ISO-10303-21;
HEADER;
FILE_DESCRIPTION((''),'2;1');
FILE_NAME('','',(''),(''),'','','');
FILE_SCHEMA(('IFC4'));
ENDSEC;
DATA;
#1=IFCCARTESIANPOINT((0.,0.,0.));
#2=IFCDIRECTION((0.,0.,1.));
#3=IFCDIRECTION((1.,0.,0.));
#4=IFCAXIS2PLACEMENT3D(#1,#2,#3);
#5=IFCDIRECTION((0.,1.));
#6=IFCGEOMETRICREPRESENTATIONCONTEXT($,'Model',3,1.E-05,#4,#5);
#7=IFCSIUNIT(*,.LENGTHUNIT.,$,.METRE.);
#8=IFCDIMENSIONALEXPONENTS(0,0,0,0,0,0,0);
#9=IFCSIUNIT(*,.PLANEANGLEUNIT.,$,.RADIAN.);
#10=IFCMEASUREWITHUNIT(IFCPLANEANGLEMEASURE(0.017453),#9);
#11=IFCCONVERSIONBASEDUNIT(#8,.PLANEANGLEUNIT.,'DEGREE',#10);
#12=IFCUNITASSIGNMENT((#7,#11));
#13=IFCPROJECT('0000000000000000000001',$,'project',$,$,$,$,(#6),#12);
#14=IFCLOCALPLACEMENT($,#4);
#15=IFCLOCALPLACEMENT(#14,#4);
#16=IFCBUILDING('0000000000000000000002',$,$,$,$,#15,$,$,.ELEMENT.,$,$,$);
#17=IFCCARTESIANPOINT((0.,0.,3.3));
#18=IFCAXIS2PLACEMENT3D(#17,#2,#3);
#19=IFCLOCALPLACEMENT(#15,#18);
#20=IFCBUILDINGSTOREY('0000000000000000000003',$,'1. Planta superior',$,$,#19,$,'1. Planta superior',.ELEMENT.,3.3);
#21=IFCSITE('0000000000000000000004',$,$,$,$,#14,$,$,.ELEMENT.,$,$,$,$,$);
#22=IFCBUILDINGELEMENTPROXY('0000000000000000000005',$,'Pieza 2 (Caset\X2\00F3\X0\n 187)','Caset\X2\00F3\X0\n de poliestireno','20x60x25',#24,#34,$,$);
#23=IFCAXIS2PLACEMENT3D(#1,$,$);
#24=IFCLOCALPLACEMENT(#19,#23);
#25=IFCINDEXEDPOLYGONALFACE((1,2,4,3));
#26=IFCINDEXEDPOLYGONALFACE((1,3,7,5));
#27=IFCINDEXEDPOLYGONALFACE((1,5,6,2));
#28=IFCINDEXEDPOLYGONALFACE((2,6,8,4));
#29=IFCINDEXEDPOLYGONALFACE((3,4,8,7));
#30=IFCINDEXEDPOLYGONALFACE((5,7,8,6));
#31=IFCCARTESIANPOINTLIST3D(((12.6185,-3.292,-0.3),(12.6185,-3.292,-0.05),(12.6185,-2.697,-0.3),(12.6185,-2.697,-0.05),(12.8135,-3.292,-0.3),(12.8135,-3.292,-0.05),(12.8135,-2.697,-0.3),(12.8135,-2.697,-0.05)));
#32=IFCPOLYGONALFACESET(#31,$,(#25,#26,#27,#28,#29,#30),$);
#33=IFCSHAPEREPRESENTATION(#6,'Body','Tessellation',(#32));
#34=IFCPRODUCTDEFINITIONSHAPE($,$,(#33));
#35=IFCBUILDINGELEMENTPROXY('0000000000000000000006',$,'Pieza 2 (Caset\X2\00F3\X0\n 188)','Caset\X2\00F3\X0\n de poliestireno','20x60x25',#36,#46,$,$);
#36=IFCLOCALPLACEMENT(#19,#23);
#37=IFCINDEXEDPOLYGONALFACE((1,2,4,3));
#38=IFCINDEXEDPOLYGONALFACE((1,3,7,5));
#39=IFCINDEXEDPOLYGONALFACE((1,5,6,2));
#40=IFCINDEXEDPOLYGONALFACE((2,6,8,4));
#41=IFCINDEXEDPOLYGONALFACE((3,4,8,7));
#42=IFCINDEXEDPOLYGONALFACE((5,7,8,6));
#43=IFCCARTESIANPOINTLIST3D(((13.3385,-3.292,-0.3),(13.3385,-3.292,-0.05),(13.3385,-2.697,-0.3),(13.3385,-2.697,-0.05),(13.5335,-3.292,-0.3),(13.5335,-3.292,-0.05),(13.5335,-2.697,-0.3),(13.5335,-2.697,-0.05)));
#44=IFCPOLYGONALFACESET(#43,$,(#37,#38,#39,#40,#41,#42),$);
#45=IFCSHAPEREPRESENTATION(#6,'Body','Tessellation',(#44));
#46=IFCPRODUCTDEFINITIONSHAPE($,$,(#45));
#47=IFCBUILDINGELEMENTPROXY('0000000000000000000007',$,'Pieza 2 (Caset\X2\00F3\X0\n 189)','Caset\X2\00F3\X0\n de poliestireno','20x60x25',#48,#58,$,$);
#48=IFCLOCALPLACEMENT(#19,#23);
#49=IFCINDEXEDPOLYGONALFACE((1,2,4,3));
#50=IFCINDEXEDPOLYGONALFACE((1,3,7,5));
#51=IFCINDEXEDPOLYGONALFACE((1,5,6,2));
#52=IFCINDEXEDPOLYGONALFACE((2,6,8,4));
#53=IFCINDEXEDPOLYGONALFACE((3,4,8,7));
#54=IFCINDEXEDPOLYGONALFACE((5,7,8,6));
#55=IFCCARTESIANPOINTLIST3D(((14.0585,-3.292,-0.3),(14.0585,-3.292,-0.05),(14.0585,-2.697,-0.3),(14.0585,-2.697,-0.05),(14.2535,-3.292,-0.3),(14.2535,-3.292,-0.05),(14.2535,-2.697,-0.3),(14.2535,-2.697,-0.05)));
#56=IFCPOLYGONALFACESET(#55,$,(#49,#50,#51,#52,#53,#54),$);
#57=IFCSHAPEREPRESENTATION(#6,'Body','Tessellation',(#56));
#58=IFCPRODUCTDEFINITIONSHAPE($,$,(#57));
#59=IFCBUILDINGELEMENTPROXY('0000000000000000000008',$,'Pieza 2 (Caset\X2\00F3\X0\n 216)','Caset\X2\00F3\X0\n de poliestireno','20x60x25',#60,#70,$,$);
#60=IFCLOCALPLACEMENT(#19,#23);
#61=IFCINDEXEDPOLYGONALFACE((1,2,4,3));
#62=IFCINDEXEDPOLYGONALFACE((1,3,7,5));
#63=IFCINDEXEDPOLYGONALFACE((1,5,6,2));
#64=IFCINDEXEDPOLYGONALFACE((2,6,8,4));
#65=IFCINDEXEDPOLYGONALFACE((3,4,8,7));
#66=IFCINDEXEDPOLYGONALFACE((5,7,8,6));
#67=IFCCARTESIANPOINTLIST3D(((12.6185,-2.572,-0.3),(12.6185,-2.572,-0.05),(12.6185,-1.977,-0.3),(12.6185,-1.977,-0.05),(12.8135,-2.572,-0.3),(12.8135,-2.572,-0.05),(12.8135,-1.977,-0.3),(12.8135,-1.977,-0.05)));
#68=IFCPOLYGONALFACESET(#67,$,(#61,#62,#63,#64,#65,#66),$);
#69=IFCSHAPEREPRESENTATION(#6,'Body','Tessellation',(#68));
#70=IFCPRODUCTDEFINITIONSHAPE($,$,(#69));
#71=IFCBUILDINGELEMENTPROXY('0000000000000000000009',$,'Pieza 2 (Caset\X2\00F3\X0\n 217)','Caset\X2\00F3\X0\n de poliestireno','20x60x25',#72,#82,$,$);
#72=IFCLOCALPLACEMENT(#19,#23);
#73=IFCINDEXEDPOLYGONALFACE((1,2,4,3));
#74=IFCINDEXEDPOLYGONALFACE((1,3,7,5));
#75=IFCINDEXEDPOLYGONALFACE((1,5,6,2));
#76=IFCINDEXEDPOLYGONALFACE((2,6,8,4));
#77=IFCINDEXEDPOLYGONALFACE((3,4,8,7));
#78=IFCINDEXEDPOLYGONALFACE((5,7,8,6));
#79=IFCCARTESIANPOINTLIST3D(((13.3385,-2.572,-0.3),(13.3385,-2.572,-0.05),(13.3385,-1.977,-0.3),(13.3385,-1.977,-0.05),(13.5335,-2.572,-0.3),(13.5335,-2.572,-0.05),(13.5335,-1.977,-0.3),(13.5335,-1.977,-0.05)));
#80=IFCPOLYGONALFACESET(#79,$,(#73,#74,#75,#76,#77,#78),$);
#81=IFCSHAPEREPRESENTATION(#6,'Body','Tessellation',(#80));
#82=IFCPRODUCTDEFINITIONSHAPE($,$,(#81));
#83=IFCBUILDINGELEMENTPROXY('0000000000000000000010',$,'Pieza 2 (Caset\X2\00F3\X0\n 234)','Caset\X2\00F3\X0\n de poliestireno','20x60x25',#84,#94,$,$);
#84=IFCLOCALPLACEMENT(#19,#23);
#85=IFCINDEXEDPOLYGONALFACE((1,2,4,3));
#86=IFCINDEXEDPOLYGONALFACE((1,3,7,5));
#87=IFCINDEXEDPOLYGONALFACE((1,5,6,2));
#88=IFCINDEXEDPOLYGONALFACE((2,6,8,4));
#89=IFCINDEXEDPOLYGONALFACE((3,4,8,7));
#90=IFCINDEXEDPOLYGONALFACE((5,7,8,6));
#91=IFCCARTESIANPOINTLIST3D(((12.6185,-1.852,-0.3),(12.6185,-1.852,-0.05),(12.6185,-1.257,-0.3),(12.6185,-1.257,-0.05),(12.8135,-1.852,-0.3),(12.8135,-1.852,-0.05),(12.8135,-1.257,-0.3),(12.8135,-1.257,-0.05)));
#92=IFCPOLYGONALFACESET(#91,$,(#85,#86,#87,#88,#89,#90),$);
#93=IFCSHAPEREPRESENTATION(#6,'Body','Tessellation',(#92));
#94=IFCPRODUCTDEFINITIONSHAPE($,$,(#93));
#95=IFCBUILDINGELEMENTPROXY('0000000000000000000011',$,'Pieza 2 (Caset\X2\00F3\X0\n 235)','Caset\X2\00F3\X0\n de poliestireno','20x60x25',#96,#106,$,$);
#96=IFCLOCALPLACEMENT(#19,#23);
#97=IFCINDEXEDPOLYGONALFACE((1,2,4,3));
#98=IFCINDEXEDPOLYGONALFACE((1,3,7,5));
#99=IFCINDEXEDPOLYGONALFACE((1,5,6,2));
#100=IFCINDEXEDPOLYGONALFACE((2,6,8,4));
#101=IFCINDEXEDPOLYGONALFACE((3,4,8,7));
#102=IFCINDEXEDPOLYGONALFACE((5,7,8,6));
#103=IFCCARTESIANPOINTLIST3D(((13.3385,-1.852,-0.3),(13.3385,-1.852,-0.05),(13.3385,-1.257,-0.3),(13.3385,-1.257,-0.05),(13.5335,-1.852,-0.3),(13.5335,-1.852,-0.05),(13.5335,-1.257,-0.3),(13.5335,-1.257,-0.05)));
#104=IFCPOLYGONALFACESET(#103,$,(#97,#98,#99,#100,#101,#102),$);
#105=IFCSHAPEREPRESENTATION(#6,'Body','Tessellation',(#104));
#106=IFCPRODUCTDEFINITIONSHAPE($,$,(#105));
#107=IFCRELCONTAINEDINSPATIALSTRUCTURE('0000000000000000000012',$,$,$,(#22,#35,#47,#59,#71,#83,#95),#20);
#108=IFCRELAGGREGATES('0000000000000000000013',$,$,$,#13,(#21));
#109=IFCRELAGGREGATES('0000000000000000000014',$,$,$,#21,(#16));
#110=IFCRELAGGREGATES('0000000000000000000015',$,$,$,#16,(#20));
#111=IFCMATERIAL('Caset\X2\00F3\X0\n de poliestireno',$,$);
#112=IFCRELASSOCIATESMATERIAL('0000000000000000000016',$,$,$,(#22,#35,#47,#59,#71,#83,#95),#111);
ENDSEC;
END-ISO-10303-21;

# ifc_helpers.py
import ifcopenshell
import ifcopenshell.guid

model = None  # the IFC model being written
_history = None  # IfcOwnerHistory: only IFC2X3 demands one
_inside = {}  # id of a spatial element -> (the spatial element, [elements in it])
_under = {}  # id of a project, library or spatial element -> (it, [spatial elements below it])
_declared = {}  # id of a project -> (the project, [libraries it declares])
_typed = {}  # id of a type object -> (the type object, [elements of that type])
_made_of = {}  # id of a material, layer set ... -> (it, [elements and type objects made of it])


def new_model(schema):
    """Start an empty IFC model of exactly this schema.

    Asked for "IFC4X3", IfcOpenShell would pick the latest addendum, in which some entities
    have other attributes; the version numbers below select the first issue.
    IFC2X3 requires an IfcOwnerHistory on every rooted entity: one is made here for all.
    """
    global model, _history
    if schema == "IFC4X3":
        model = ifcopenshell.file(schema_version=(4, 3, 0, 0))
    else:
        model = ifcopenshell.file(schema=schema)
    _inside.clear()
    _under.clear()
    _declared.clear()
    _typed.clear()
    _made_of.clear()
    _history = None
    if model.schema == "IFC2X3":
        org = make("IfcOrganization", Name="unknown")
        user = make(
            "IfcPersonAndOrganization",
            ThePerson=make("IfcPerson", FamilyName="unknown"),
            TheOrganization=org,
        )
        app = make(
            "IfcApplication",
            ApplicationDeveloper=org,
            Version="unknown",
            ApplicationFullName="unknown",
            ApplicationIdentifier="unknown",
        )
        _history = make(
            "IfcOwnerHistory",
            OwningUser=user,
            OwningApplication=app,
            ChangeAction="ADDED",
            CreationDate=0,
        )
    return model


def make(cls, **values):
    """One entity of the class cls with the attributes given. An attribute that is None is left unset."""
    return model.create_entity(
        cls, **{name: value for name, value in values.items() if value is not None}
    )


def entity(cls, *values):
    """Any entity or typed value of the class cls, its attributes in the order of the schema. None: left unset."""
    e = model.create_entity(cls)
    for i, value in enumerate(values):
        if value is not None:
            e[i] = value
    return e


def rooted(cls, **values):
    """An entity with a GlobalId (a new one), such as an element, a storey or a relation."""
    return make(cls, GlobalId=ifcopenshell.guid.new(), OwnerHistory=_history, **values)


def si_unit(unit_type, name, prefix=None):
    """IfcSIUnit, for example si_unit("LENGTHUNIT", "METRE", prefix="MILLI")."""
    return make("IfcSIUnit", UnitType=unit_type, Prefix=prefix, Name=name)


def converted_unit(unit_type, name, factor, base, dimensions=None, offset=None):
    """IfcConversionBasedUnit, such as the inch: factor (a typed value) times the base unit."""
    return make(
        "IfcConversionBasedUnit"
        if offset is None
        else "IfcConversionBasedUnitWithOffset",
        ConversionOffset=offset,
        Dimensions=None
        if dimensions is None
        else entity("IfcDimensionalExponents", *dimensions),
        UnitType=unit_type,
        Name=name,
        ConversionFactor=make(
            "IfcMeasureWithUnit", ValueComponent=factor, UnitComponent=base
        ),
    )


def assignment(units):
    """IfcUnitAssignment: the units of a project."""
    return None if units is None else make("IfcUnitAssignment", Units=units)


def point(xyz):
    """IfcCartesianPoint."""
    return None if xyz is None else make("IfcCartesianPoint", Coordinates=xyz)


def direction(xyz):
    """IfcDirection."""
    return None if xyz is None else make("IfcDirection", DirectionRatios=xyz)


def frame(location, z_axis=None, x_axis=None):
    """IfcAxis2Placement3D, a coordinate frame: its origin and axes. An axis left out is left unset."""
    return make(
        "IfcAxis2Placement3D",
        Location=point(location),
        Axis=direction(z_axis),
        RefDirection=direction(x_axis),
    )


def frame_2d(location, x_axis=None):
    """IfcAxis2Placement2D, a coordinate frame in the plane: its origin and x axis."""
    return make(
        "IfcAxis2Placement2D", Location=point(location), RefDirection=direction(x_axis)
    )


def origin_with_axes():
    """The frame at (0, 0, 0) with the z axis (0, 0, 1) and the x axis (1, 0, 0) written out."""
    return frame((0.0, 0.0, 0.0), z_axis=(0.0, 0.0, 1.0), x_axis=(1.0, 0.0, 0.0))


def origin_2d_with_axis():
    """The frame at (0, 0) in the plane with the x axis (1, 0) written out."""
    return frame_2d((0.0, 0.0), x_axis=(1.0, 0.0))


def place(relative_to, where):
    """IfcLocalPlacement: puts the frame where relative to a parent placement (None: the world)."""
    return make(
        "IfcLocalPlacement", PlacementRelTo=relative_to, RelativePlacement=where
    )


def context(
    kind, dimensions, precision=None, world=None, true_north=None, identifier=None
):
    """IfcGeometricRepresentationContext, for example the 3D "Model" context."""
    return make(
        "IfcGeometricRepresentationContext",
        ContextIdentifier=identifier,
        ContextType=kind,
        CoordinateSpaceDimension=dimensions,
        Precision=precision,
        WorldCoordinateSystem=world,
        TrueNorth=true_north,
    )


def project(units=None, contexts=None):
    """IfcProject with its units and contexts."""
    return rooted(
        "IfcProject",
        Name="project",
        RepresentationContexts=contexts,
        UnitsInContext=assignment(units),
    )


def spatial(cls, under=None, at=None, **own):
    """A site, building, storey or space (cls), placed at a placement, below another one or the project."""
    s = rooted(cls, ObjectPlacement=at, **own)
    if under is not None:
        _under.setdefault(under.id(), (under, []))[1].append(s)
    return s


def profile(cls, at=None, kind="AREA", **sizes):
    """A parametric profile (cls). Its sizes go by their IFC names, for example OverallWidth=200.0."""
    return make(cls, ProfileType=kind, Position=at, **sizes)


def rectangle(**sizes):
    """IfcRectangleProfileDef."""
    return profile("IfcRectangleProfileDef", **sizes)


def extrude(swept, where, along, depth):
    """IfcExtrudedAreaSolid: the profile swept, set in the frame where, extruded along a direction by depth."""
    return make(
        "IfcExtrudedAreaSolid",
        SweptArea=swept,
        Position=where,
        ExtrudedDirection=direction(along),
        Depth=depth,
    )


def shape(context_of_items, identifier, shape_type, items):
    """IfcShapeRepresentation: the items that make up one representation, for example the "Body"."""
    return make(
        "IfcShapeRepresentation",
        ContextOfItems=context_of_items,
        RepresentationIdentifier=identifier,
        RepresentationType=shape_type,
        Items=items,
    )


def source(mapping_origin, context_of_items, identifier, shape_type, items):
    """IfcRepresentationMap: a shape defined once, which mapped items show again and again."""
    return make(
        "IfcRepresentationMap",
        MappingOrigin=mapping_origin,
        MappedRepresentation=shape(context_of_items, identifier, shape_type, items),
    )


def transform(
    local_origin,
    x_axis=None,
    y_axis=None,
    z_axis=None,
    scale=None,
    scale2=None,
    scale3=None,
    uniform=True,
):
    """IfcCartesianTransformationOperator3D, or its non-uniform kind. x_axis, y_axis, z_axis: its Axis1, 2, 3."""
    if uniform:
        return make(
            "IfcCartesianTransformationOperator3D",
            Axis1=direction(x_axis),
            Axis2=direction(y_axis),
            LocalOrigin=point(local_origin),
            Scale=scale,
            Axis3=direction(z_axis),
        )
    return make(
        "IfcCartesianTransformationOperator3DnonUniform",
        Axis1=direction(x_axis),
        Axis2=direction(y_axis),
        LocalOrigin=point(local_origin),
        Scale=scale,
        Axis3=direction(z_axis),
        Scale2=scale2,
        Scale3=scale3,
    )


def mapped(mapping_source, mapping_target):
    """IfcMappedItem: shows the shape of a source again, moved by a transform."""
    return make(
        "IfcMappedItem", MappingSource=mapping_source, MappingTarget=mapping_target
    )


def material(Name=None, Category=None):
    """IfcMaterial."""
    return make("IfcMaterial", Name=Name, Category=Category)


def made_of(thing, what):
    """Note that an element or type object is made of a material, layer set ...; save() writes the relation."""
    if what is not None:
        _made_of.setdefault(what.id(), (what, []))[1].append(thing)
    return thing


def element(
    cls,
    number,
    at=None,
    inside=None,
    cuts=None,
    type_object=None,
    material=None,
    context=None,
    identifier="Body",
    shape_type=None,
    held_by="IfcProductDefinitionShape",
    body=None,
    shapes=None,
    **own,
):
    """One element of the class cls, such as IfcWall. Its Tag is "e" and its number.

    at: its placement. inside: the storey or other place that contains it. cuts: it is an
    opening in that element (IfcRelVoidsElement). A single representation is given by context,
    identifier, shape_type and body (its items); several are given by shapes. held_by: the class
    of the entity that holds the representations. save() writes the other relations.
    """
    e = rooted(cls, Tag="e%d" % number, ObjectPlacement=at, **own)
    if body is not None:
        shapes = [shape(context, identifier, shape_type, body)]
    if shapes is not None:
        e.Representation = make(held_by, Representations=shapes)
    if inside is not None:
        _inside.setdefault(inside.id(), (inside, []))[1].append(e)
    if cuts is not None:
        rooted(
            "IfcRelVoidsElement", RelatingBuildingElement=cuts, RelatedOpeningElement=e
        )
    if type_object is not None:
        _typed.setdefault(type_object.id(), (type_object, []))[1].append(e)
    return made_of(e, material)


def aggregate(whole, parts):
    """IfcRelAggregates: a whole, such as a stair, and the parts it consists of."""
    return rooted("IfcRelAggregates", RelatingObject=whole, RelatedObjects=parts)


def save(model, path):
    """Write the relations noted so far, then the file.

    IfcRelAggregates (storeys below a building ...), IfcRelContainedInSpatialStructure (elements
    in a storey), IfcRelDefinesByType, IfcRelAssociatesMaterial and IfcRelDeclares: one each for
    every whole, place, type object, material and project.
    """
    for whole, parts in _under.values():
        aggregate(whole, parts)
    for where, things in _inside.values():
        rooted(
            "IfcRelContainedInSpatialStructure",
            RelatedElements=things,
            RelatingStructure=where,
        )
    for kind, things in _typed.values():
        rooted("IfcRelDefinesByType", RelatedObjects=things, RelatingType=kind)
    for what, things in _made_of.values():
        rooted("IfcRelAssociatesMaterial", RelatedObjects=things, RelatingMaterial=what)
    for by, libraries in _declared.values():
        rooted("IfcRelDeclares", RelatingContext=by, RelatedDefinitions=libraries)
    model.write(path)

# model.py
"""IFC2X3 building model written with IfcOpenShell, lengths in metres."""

from ifc_helpers import new_model, entity, si_unit, converted_unit, direction, frame, origin_with_axes, origin_2d_with_axis, place, context, project, spatial, rectangle, extrude, source, transform, mapped, material, element, save


model = new_model("IFC2X3")

# Units and contexts
model_context = context("Model", 3, precision=1e-05, world=origin_with_axes(), true_north=direction((0.0, 1.0)))
ifc_project = project(units=[si_unit("LENGTHUNIT", "METRE"), converted_unit("PLANEANGLEUNIT", "DEGREE", entity("IfcPlaneAngleMeasure", 0.017453), si_unit("PLANEANGLEUNIT", "RADIAN"), dimensions=[0, 0, 0, 0, 0, 0, 0])], contexts=[model_context])

# Site, building, storey
site_placement = place(None, origin_with_axes())
site = spatial("IfcSite", under=ifc_project, at=site_placement, CompositionType="ELEMENT")
building_placement = place(site_placement, origin_with_axes())
building = spatial("IfcBuilding", under=site, at=building_placement, CompositionType="ELEMENT")
storey_placement = place(building_placement, frame((0.0, 0.0, 3.3), z_axis=(0.0, 0.0, 1.0), x_axis=(1.0, 0.0, 0.0)))
storey = spatial("IfcBuildingStorey", under=building, at=storey_placement, Name="1. Planta superior", LongName="1. Planta superior", CompositionType="ELEMENT", Elevation=3.3)

# Building element proxies
ifc_material = material(Name="Casetón de poliestireno")
shared_shape = source(origin_with_axes(), model_context, "Body", "SweptSolid", [
    extrude(rectangle(XDim=0.195, YDim=0.25, at=origin_2d_with_axis()), origin_with_axes(), (0.0, 0.0, 1.0), 0.595),
])
placement_1 = place(storey_placement, frame((12.716, -3.292, -0.175), z_axis=(0.0, 1.0, 0.0), x_axis=(-1.0, 0.0, 0.0)))
for number, where, z_axis, x_axis, name in (
    (1, (0.0, 0.0, 0.0), (0.0, 0.0, 1.0), (1.0, 0.0, 0.0), "Pieza 2 (Casetón 187)"),
):
    element("IfcBuildingElementProxy", number, at=place(placement_1, frame(where, z_axis=z_axis, x_axis=x_axis)), inside=storey, material=ifc_material, Name=name, Description="Casetón de poliestireno", ObjectType="20x60x25", context=model_context, shape_type="MappedRepresentation", body=[
        mapped(shared_shape, transform((0.0, 0.0, 0.0), x_axis=(1.0, 0.0, 0.0), y_axis=(0.0, 1.0, 0.0), z_axis=(0.0, 0.0, 1.0))),
    ])
placement_2 = place(storey_placement, frame((13.436, -3.292, -0.175), z_axis=(0.0, 1.0, 0.0), x_axis=(-1.0, 0.0, 0.0)))
for number, where, z_axis, x_axis, name in (
    (2, (0.0, 0.0, 0.0), (0.0, 0.0, 1.0), (1.0, 0.0, 0.0), "Pieza 2 (Casetón 188)"),
):
    element("IfcBuildingElementProxy", number, at=place(placement_2, frame(where, z_axis=z_axis, x_axis=x_axis)), inside=storey, material=ifc_material, Name=name, Description="Casetón de poliestireno", ObjectType="20x60x25", context=model_context, shape_type="MappedRepresentation", body=[
        mapped(shared_shape, transform((0.0, 0.0, 0.0), x_axis=(1.0, 0.0, 0.0), y_axis=(0.0, 1.0, 0.0), z_axis=(0.0, 0.0, 1.0))),
    ])
placement_3 = place(storey_placement, frame((14.156, -3.292, -0.175), z_axis=(0.0, 1.0, 0.0), x_axis=(-1.0, 0.0, 0.0)))
for number, where, z_axis, x_axis, name in (
    (3, (0.0, 0.0, 0.0), (0.0, 0.0, 1.0), (1.0, 0.0, 0.0), "Pieza 2 (Casetón 189)"),
):
    element("IfcBuildingElementProxy", number, at=place(placement_3, frame(where, z_axis=z_axis, x_axis=x_axis)), inside=storey, material=ifc_material, Name=name, Description="Casetón de poliestireno", ObjectType="20x60x25", context=model_context, shape_type="MappedRepresentation", body=[
        mapped(shared_shape, transform((0.0, 0.0, 0.0), x_axis=(1.0, 0.0, 0.0), y_axis=(0.0, 1.0, 0.0), z_axis=(0.0, 0.0, 1.0))),
    ])
placement_4 = place(storey_placement, frame((12.716, -2.572, -0.175), z_axis=(0.0, 1.0, 0.0), x_axis=(-1.0, 0.0, 0.0)))
for number, where, z_axis, x_axis, name in (
    (4, (0.0, 0.0, 0.0), (0.0, 0.0, 1.0), (1.0, 0.0, 0.0), "Pieza 2 (Casetón 216)"),
):
    element("IfcBuildingElementProxy", number, at=place(placement_4, frame(where, z_axis=z_axis, x_axis=x_axis)), inside=storey, material=ifc_material, Name=name, Description="Casetón de poliestireno", ObjectType="20x60x25", context=model_context, shape_type="MappedRepresentation", body=[
        mapped(shared_shape, transform((0.0, 0.0, 0.0), x_axis=(1.0, 0.0, 0.0), y_axis=(0.0, 1.0, 0.0), z_axis=(0.0, 0.0, 1.0))),
    ])
placement_5 = place(storey_placement, frame((13.436, -2.572, -0.175), z_axis=(0.0, 1.0, 0.0), x_axis=(-1.0, 0.0, 0.0)))
for number, where, z_axis, x_axis, name in (
    (5, (0.0, 0.0, 0.0), (0.0, 0.0, 1.0), (1.0, 0.0, 0.0), "Pieza 2 (Casetón 217)"),
):
    element("IfcBuildingElementProxy", number, at=place(placement_5, frame(where, z_axis=z_axis, x_axis=x_axis)), inside=storey, material=ifc_material, Name=name, Description="Casetón de poliestireno", ObjectType="20x60x25", context=model_context, shape_type="MappedRepresentation", body=[
        mapped(shared_shape, transform((0.0, 0.0, 0.0), x_axis=(1.0, 0.0, 0.0), y_axis=(0.0, 1.0, 0.0), z_axis=(0.0, 0.0, 1.0))),
    ])
placement_6 = place(storey_placement, frame((12.716, -1.852, -0.175), z_axis=(0.0, 1.0, 0.0), x_axis=(-1.0, 0.0, 0.0)))
for number, where, z_axis, x_axis, name in (
    (6, (0.0, 0.0, 0.0), (0.0, 0.0, 1.0), (1.0, 0.0, 0.0), "Pieza 2 (Casetón 234)"),
):
    element("IfcBuildingElementProxy", number, at=place(placement_6, frame(where, z_axis=z_axis, x_axis=x_axis)), inside=storey, material=ifc_material, Name=name, Description="Casetón de poliestireno", ObjectType="20x60x25", context=model_context, shape_type="MappedRepresentation", body=[
        mapped(shared_shape, transform((0.0, 0.0, 0.0), x_axis=(1.0, 0.0, 0.0), y_axis=(0.0, 1.0, 0.0), z_axis=(0.0, 0.0, 1.0))),
    ])
placement_7 = place(storey_placement, frame((13.436, -1.852, -0.175), z_axis=(0.0, 1.0, 0.0), x_axis=(-1.0, 0.0, 0.0)))
for number, where, z_axis, x_axis, name in (
    (7, (0.0, 0.0, 0.0), (0.0, 0.0, 1.0), (1.0, 0.0, 0.0), "Pieza 2 (Casetón 235)"),
):
    element("IfcBuildingElementProxy", number, at=place(placement_7, frame(where, z_axis=z_axis, x_axis=x_axis)), inside=storey, material=ifc_material, Name=name, Description="Casetón de poliestireno", ObjectType="20x60x25", context=model_context, shape_type="MappedRepresentation", body=[
        mapped(shared_shape, transform((0.0, 0.0, 0.0), x_axis=(1.0, 0.0, 0.0), y_axis=(0.0, 1.0, 0.0), z_axis=(0.0, 0.0, 1.0))),
    ])

save(model, "model.ifc")
